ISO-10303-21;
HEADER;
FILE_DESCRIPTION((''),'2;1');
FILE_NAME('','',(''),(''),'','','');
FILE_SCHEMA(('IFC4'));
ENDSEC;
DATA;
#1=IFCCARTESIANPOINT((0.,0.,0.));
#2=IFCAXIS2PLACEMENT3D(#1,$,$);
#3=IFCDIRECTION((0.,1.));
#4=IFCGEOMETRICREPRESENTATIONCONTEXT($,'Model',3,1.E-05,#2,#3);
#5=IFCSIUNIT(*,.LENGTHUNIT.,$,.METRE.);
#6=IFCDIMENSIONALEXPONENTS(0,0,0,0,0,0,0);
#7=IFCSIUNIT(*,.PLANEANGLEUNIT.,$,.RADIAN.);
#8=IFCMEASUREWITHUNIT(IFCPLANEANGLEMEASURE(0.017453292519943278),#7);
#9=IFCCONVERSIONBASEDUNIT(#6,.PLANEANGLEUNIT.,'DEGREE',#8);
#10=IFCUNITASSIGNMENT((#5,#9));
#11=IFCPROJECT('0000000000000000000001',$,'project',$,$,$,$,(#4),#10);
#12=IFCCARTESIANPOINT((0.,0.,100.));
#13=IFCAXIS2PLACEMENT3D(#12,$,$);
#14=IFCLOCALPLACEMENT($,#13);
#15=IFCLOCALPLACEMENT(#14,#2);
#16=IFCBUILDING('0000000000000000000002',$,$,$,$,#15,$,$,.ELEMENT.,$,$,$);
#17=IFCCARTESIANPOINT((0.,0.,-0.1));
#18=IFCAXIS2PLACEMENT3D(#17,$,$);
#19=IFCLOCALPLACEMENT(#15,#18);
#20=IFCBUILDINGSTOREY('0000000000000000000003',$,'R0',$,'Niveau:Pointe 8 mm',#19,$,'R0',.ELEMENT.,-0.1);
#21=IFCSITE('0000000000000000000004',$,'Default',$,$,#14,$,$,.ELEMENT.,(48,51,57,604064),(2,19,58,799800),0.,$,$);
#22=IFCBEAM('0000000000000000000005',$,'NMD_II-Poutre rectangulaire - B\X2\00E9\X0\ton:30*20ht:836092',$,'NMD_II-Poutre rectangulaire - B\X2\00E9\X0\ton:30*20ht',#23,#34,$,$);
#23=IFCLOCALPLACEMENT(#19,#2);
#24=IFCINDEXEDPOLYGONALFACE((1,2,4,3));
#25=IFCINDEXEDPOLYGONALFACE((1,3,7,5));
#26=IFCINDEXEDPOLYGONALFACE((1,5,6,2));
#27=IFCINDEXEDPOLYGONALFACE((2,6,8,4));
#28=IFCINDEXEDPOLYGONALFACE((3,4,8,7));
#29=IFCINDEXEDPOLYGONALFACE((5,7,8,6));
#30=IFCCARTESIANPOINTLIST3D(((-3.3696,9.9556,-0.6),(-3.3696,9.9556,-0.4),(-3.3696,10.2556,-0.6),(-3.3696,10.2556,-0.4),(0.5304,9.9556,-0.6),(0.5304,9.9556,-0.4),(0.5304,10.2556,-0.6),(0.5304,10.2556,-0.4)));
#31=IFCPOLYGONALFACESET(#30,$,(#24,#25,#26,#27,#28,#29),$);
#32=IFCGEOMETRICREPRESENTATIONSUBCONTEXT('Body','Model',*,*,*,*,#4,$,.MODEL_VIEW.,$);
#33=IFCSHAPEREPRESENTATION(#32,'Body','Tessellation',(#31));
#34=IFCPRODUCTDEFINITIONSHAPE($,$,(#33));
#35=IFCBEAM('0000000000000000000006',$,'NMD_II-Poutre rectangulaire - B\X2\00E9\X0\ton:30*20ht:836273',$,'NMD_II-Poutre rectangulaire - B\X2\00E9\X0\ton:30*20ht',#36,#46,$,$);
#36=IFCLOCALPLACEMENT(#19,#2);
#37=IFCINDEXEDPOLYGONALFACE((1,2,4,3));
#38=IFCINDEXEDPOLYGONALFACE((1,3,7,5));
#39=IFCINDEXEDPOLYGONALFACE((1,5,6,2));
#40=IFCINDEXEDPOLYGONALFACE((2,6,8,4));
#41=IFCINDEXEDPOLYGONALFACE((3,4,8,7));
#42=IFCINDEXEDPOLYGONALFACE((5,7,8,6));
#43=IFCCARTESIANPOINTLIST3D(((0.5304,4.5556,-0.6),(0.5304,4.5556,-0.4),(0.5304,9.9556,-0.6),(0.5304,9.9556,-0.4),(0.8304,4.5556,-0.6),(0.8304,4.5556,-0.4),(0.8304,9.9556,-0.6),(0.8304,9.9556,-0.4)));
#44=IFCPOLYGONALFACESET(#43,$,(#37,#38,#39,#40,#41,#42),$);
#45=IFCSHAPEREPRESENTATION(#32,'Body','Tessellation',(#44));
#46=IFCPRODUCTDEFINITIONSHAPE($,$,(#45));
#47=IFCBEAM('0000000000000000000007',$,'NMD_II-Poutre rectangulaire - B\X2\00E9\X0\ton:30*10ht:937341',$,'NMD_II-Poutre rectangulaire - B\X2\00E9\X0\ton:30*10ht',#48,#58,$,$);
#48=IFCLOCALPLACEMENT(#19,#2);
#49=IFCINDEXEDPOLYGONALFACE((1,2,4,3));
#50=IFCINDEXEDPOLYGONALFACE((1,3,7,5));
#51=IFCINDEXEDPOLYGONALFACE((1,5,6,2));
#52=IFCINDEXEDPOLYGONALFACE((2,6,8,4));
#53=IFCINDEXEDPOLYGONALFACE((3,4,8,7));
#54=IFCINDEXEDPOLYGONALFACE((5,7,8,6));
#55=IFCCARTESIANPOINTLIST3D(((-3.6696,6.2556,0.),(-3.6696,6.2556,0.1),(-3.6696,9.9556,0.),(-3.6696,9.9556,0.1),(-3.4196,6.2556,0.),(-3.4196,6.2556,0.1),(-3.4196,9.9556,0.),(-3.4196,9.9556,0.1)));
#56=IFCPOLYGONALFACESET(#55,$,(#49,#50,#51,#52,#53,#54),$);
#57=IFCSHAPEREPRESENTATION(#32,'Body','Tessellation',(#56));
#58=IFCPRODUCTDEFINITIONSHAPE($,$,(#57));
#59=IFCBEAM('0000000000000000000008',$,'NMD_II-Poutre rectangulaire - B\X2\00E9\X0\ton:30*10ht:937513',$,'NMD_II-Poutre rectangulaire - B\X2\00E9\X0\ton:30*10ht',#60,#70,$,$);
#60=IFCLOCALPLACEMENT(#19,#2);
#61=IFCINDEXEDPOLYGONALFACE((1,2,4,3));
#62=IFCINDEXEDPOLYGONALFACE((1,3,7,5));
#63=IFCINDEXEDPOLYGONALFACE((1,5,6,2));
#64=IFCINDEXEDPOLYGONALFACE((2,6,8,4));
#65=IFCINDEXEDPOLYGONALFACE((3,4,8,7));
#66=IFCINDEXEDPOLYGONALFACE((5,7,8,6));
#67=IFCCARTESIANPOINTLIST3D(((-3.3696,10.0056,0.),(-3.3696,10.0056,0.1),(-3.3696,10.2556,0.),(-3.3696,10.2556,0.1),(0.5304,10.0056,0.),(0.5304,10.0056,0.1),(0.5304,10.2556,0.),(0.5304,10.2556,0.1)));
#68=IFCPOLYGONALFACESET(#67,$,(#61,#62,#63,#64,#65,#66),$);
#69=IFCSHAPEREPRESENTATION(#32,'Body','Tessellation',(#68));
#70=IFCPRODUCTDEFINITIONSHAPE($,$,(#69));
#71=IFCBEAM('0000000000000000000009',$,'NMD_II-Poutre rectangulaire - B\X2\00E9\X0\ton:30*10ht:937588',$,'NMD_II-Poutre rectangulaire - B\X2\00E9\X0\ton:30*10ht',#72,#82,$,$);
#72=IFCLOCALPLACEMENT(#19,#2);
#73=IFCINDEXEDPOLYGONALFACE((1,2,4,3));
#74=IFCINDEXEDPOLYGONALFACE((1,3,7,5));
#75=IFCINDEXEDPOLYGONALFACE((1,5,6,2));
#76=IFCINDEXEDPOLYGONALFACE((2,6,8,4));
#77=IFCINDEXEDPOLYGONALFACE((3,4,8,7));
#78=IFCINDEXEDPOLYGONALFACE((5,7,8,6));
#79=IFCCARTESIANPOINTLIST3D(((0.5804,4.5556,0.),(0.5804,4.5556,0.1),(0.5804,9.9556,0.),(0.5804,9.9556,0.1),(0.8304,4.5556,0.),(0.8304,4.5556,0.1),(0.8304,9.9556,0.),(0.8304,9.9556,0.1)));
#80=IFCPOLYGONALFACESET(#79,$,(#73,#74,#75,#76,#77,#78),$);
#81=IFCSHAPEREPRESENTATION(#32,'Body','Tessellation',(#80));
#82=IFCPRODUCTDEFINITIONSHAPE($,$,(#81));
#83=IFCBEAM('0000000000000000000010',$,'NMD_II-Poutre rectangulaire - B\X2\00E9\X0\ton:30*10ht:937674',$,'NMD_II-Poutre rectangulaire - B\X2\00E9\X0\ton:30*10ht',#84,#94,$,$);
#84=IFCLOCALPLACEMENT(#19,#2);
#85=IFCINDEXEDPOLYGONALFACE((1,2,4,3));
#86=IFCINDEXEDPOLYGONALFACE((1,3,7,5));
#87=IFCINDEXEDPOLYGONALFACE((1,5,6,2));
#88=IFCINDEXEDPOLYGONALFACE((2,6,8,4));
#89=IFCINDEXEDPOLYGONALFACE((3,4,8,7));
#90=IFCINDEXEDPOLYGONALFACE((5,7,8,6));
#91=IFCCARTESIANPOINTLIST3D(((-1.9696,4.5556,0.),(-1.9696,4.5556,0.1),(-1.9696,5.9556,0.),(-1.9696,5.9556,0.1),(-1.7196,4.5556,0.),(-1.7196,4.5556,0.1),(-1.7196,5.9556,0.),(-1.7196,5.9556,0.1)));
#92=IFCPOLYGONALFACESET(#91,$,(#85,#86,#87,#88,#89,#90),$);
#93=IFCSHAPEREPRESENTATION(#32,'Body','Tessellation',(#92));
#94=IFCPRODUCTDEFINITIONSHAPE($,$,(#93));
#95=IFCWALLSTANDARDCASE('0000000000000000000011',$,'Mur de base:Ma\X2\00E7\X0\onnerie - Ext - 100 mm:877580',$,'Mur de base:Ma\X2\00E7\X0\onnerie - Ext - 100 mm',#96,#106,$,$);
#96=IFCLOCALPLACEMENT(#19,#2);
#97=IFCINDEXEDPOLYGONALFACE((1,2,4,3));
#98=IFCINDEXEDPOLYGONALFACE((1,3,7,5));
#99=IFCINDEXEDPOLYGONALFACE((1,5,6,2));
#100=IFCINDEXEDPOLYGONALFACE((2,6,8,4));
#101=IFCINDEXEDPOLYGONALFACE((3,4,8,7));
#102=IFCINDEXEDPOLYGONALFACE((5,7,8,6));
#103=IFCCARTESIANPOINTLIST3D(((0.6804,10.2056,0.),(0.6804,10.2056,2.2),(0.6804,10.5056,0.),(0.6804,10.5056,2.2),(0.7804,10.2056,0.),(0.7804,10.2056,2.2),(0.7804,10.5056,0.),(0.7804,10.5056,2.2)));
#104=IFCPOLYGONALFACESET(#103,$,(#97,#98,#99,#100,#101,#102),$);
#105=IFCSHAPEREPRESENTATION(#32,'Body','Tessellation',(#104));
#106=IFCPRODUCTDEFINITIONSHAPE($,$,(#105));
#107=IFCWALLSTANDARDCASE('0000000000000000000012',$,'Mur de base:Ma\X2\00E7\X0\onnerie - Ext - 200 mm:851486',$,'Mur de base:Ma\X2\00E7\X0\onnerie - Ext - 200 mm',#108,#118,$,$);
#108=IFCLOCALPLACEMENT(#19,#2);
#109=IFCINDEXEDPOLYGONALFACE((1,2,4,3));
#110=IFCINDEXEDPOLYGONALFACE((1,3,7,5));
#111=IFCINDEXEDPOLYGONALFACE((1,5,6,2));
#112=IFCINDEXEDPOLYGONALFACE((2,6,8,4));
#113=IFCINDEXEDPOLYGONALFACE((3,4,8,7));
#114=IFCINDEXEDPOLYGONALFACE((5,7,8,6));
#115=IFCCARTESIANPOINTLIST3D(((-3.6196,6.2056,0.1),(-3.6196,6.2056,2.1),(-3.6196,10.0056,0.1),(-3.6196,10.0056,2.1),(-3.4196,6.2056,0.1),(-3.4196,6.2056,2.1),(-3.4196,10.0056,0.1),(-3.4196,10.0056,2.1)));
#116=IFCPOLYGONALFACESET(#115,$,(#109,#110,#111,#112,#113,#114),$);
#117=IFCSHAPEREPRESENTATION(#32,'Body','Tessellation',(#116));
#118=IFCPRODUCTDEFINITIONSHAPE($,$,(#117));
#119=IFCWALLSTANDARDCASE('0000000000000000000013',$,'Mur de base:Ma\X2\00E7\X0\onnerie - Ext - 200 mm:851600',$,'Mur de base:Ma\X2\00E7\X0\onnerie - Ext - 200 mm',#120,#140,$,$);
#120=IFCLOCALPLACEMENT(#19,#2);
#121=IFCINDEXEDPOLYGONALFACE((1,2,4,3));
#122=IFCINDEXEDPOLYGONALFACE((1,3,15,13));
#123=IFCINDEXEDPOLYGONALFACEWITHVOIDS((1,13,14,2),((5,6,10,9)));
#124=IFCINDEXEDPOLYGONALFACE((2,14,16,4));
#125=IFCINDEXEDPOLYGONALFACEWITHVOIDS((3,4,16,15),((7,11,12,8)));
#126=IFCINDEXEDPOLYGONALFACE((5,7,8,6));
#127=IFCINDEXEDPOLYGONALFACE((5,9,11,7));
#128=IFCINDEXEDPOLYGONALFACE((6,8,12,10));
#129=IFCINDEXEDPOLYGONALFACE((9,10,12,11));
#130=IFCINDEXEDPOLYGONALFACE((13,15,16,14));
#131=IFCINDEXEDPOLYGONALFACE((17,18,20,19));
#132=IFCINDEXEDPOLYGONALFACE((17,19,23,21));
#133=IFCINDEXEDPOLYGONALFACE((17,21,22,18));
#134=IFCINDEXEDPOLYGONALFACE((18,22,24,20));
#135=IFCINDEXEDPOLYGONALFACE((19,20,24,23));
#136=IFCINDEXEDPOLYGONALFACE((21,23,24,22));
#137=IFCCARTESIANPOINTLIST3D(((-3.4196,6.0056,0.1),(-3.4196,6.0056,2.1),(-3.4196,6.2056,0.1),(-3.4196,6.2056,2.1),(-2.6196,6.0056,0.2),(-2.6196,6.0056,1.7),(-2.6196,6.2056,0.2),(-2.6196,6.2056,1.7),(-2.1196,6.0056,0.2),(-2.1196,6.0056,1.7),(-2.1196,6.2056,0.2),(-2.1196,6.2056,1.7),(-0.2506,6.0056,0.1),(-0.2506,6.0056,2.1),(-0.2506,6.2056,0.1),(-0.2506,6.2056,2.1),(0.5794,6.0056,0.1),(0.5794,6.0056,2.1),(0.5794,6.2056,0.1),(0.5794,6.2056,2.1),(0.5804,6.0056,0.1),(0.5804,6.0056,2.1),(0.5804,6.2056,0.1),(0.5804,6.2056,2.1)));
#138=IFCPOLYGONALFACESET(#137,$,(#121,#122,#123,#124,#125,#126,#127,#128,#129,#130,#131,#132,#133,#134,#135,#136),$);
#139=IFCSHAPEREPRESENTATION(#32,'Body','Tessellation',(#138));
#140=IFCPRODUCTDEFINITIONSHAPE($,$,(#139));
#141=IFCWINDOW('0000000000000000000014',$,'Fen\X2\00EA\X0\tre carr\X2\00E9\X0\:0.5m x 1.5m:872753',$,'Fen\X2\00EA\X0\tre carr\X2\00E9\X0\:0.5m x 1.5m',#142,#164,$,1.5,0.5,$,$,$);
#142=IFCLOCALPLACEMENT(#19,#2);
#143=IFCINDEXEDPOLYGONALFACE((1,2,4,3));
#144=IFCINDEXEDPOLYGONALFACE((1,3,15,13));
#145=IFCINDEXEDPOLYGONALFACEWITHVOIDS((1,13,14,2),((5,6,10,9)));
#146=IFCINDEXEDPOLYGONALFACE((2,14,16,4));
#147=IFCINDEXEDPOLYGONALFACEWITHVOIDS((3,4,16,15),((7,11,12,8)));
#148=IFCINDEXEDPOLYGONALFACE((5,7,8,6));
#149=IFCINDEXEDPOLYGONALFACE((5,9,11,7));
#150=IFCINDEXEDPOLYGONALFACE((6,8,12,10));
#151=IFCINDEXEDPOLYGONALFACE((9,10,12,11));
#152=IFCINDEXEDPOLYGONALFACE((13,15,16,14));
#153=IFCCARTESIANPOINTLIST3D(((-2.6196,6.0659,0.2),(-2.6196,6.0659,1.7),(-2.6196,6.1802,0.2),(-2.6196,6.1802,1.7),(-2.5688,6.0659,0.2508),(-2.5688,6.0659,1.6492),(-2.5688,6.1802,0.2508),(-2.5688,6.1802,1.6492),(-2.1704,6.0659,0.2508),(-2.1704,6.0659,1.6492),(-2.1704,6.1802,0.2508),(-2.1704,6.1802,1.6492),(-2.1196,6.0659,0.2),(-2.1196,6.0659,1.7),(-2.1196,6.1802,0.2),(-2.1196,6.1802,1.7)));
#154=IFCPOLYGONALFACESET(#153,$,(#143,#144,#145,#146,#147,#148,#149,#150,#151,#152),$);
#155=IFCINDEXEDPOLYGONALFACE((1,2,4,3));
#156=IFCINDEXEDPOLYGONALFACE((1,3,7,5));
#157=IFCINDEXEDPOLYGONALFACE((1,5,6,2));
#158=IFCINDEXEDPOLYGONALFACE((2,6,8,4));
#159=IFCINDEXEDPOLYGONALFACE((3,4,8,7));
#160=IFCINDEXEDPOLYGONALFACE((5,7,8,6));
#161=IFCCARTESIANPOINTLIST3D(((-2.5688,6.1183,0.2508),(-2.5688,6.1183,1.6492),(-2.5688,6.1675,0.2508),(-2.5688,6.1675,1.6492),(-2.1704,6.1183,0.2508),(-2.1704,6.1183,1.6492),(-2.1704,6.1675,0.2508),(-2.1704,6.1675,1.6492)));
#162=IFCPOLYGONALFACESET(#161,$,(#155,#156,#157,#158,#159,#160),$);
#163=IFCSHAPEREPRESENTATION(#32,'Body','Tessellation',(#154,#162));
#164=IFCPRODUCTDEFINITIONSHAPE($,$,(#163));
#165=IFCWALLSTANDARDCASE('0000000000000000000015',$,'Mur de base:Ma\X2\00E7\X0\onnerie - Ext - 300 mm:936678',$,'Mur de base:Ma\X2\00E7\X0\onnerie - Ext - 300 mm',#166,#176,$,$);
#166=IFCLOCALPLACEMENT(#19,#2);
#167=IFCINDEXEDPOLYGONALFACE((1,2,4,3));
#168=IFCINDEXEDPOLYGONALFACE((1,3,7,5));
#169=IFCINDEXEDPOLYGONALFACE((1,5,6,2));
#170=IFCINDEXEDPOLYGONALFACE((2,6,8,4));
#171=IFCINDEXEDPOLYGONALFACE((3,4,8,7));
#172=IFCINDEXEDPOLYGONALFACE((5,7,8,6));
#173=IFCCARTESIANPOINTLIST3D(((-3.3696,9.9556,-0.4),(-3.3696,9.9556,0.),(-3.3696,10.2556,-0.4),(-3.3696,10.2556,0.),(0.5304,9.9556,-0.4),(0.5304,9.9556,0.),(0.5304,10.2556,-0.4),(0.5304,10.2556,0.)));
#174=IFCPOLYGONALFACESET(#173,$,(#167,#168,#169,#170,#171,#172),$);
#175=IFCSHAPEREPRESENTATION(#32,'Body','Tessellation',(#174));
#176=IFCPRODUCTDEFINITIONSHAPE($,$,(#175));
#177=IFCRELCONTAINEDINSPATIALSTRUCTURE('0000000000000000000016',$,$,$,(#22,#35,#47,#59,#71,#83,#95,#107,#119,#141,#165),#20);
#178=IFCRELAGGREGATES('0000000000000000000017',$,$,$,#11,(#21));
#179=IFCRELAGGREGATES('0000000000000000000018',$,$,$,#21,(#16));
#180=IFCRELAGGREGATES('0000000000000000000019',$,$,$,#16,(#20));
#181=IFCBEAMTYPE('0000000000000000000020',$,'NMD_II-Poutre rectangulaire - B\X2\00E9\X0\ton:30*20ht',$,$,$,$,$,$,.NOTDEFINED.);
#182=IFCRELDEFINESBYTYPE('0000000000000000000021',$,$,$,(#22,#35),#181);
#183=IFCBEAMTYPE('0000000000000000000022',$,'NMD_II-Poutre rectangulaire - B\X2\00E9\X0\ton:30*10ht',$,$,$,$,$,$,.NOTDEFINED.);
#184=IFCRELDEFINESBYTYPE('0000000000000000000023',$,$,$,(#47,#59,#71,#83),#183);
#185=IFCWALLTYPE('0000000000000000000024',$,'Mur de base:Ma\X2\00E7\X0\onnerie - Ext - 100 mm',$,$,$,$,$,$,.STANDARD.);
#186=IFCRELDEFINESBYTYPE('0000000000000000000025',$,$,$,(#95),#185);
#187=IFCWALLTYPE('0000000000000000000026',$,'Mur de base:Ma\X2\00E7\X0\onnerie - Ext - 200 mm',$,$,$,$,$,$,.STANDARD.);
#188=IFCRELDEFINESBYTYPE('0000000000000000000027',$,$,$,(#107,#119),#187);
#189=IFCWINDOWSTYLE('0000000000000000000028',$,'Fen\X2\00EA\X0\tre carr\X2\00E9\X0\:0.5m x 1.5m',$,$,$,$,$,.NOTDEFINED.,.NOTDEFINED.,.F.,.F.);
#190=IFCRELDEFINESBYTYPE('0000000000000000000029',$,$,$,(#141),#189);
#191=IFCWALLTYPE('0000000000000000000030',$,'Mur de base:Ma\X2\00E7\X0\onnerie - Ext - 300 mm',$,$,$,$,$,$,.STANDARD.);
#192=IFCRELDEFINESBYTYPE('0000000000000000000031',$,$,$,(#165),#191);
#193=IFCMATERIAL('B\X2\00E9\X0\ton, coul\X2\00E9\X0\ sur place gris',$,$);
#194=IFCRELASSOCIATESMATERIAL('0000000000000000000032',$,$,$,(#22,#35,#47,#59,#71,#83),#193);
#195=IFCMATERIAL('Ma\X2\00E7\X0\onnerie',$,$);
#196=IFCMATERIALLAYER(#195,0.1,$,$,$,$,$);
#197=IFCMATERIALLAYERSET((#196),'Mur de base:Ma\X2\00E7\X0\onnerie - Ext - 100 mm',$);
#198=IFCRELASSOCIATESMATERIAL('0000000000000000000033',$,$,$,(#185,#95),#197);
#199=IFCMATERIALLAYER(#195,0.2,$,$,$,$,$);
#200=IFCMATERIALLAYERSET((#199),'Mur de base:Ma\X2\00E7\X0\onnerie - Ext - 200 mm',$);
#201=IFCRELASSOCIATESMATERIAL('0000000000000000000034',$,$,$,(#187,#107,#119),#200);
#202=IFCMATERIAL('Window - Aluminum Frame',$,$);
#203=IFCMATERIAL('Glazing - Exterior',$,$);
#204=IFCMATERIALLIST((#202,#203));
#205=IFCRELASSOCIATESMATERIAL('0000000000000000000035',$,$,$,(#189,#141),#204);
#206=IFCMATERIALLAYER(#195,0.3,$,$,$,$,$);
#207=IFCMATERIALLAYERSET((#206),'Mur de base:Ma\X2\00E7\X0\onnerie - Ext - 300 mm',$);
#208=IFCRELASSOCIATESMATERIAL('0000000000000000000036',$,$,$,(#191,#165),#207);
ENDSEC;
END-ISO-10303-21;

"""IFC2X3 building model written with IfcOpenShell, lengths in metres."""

from ifc_helpers import new_model, entity, si_unit, converted_unit, direction, frame, frame_2d, origin, place, context, subcontext, project, spatial, polyline, rectangle, outline, extrude, clip, bounded_halfspace, source, transform, mapped, material, material_list, layer, layer_set, layer_usage, type_object, type_shapes, element, fill, save


model = new_model("IFC2X3")

# Units and contexts
model_context = context("Model", 3, precision=1e-05, world=origin(), true_north=direction((0.0, 1.0)))
body_context = subcontext(model_context, "Body", "Model", "MODEL_VIEW")
ifc_project = project(units=[si_unit("LENGTHUNIT", "METRE"), converted_unit("PLANEANGLEUNIT", "DEGREE", entity("IfcPlaneAngleMeasure", 0.017453292519943278), si_unit("PLANEANGLEUNIT", "RADIAN"), dimensions=[0, 0, 0, 0, 0, 0, 0])], contexts=[model_context])

# Site, building, storey
site_placement = place(None, frame((0.0, 0.0, 100.0)))
site = spatial("IfcSite", under=ifc_project, at=site_placement, Name="Default", CompositionType="ELEMENT", RefLatitude=(48, 51, 57, 604064), RefLongitude=(2, 19, 58, 799800), RefElevation=0.0)
building_placement = place(site_placement, origin())
building = spatial("IfcBuilding", under=site, at=building_placement, CompositionType="ELEMENT")
storey_placement = place(building_placement, frame((0.0, 0.0, -0.1)))
storey = spatial("IfcBuildingStorey", under=building, at=storey_placement, Name="R0", ObjectType="Niveau:Pointe 8 mm", LongName="R0", CompositionType="ELEMENT", Elevation=-0.1)

# Beams
ifc_material_1 = material(Name="Béton, coulé sur place gris")
beam_type_1 = type_object("IfcBeamType", Name="NMD_II-Poutre rectangulaire - Béton:30*20ht", PredefinedType="NOTDEFINED")
beam_1_placement = place(storey_placement, frame((-3.3696, 10.1056, -0.4)))
element("IfcBeam", 1, at=beam_1_placement, inside=storey, type_object=beam_type_1, material=ifc_material_1, Name="NMD_II-Poutre rectangulaire - Béton:30*20ht:836092", ObjectType="NMD_II-Poutre rectangulaire - Béton:30*20ht", context=body_context, shape_type="SweptSolid", body=[
    extrude(rectangle(XDim=0.2, YDim=0.3, at=frame_2d((0.0, 0.0), x_axis=(1.0, 0.0))), frame((0.0, 0.0, -0.1), z_axis=(1.0, 0.0, 0.0), x_axis=(0.0, 0.0, -1.0)), (0.0, 0.0, 1.0), 3.9),
])
beam_2_placement = place(storey_placement, frame((0.6804, 4.5556, -0.4), z_axis=(0.0, 0.0, 1.0), x_axis=(0.0, 1.0, 0.0)))
element("IfcBeam", 2, at=beam_2_placement, inside=storey, type_object=beam_type_1, material=ifc_material_1, Name="NMD_II-Poutre rectangulaire - Béton:30*20ht:836273", ObjectType="NMD_II-Poutre rectangulaire - Béton:30*20ht", context=body_context, shape_type="SweptSolid", body=[
    extrude(rectangle(XDim=0.2, YDim=0.3, at=frame_2d((0.0, 0.0), x_axis=(1.0, 0.0))), frame((0.0, 0.0, -0.1), z_axis=(1.0, 0.0, 0.0), x_axis=(0.0, 0.0, -1.0)), (0.0, 0.0, 1.0), 5.4),
])
beam_type_2 = type_object("IfcBeamType", Name="NMD_II-Poutre rectangulaire - Béton:30*10ht", PredefinedType="NOTDEFINED")
beam_3_placement = place(storey_placement, frame((-3.5196, 9.9556, 0.1), z_axis=(0.0, 0.0, 1.0), x_axis=(0.0, -1.0, 0.0)))
element("IfcBeam", 3, at=beam_3_placement, inside=storey, type_object=beam_type_2, material=ifc_material_1, Name="NMD_II-Poutre rectangulaire - Béton:30*10ht:937341", ObjectType="NMD_II-Poutre rectangulaire - Béton:30*10ht", context=body_context, shape_type="SweptSolid", body=[
    extrude(rectangle(XDim=0.1, YDim=0.25, at=frame_2d((0.0, 0.0), x_axis=(1.0, 0.0))), frame((0.0, -0.025, -0.05), z_axis=(1.0, 0.0, 0.0), x_axis=(0.0, 0.0, -1.0)), (0.0, 0.0, 1.0), 3.7),
])
beam_4_placement = place(storey_placement, frame((-3.3696, 10.1056, 0.1)))
element("IfcBeam", 4, at=beam_4_placement, inside=storey, type_object=beam_type_2, material=ifc_material_1, Name="NMD_II-Poutre rectangulaire - Béton:30*10ht:937513", ObjectType="NMD_II-Poutre rectangulaire - Béton:30*10ht", context=body_context, shape_type="SweptSolid", body=[
    extrude(rectangle(XDim=0.1, YDim=0.25, at=frame_2d((0.0, 0.0), x_axis=(1.0, 0.0))), frame((0.0, 0.025, -0.05), z_axis=(1.0, 0.0, 0.0), x_axis=(0.0, 0.0, -1.0)), (0.0, 0.0, 1.0), 3.9),
])
beam_5_placement = place(storey_placement, frame((0.6804, 4.5556, 0.1), z_axis=(0.0, 0.0, 1.0), x_axis=(0.0, 1.0, 0.0)))
element("IfcBeam", 5, at=beam_5_placement, inside=storey, type_object=beam_type_2, material=ifc_material_1, Name="NMD_II-Poutre rectangulaire - Béton:30*10ht:937588", ObjectType="NMD_II-Poutre rectangulaire - Béton:30*10ht", context=body_context, shape_type="SweptSolid", body=[
    extrude(rectangle(XDim=0.1, YDim=0.25, at=frame_2d((0.0, 0.0), x_axis=(1.0, 0.0))), frame((0.0, -0.025, -0.05), z_axis=(1.0, 0.0, 0.0), x_axis=(0.0, 0.0, -1.0)), (0.0, 0.0, 1.0), 5.4),
])
beam_6_placement = place(storey_placement, frame((-1.8196, 5.9556, 0.1), z_axis=(0.0, 0.0, 1.0), x_axis=(0.0, -1.0, 0.0)))
element("IfcBeam", 6, at=beam_6_placement, inside=storey, type_object=beam_type_2, material=ifc_material_1, Name="NMD_II-Poutre rectangulaire - Béton:30*10ht:937674", ObjectType="NMD_II-Poutre rectangulaire - Béton:30*10ht", context=body_context, shape_type="SweptSolid", body=[
    extrude(rectangle(XDim=0.1, YDim=0.25, at=frame_2d((0.0, 0.0), x_axis=(1.0, 0.0))), frame((0.0, -0.025, -0.05), z_axis=(1.0, 0.0, 0.0), x_axis=(0.0, 0.0, -1.0)), (0.0, 0.0, 1.0), 1.4),
])

# Walls
ifc_material_2 = material(Name="Maçonnerie")
ifc_layer_1 = layer(ifc_material_2, 0.1)
ifc_layer_set_1 = layer_set([ifc_layer_1], Name="Mur de base:Maçonnerie - Ext - 100 mm")
ifc_layer_usage_1 = layer_usage(ifc_layer_set_1, "AXIS2", "NEGATIVE", 0.05)
wall_type_1 = type_object("IfcWallType", Name="Mur de base:Maçonnerie - Ext - 100 mm", PredefinedType="STANDARD", material=ifc_layer_set_1)
wall_1_placement = place(storey_placement, frame((0.7304, 10.2056, 0.0), z_axis=(0.0, 0.0, 1.0), x_axis=(0.0, 1.0, 0.0)))
element("IfcWallStandardCase", 7, at=wall_1_placement, inside=storey, type_object=wall_type_1, material=ifc_layer_usage_1, Name="Mur de base:Maçonnerie - Ext - 100 mm:877580", ObjectType="Mur de base:Maçonnerie - Ext - 100 mm", context=body_context, shape_type="SweptSolid", body=[
    extrude(rectangle(XDim=0.3, YDim=0.1, at=frame_2d((0.15, 0.0), x_axis=(-1.0, 0.0))), origin(), (0.0, 0.0, 1.0), 2.2),
])
ifc_layer_2 = layer(ifc_material_2, 0.2)
ifc_layer_set_2 = layer_set([ifc_layer_2], Name="Mur de base:Maçonnerie - Ext - 200 mm")
ifc_layer_usage_2 = layer_usage(ifc_layer_set_2, "AXIS2", "NEGATIVE", 0.1)
wall_type_2 = type_object("IfcWallType", Name="Mur de base:Maçonnerie - Ext - 200 mm", PredefinedType="STANDARD", material=ifc_layer_set_2)
wall_2_placement = place(storey_placement, frame((-3.5196, 10.0056, 0.1), z_axis=(0.0, 0.0, 1.0), x_axis=(0.0, -1.0, 0.0)))
element("IfcWallStandardCase", 8, at=wall_2_placement, inside=storey, type_object=wall_type_2, material=ifc_layer_usage_2, Name="Mur de base:Maçonnerie - Ext - 200 mm:851486", ObjectType="Mur de base:Maçonnerie - Ext - 200 mm", context=body_context, shape_type="Clipping", body=[
    clip(extrude(rectangle(XDim=3.8, YDim=0.2, at=frame_2d((1.9, 0.0), x_axis=(-1.0, 0.0))), origin(), (0.0, 0.0, 1.0), 2.0), bounded_halfspace(frame((3.8, -0.1, 2.0), z_axis=(-1.0, 0.0, 0.0), x_axis=(0.0, 0.0, -1.0)), True, frame((3.8, -0.1, 2.0), z_axis=(-1.0, 0.0, 0.0), x_axis=(0.0, 0.0, -1.0)), polyline([(0.0, 0.0), (0.0, -0.2), (2.0, -0.2), (2.0, 0.0), (0.0, 0.0)]))),
])

# Wall, openings, window
ifc_layer_usage_3 = layer_usage(ifc_layer_set_2, "AXIS2", "NEGATIVE", 0.1)
wall_3_placement = place(storey_placement, frame((-3.4196, 6.1056, 0.1)))
wall_3 = element("IfcWallStandardCase", 9, at=wall_3_placement, inside=storey, type_object=wall_type_2, material=ifc_layer_usage_3, Name="Mur de base:Maçonnerie - Ext - 200 mm:851600", ObjectType="Mur de base:Maçonnerie - Ext - 200 mm", context=body_context, shape_type="SweptSolid", body=[
    extrude(rectangle(XDim=4.0, YDim=0.2, at=frame_2d((2.0, 0.0), x_axis=(-1.0, 0.0))), origin(), (0.0, 0.0, 1.0), 2.0),
])
opening_1_placement = place(wall_3_placement, frame((3.999, 0.1, 0.0)))
element("IfcOpeningElement", 10, at=opening_1_placement, cuts=wall_3, ObjectType="Opening", context=body_context, shape_type="SweptSolid", body=[
    extrude(rectangle(XDim=2.0, YDim=0.83, at=frame_2d((1.0, 0.415), x_axis=(1.0, 0.0))), frame((0.0, 0.0, 0.0), z_axis=(0.0, -1.0, 0.0), x_axis=(0.0, 0.0, 1.0)), (0.0, 0.0, 1.0), 0.2),
])
opening_2_placement = place(wall_3_placement, frame((0.8, -0.1, 0.1)))
opening_2 = element("IfcOpeningElement", 11, at=opening_2_placement, cuts=wall_3, ObjectType="Opening", context=body_context, shape_type="SweptSolid", body=[
    extrude(rectangle(XDim=1.5, YDim=0.5, at=frame_2d((0.75, 0.25), x_axis=(-1.0, 0.0))), frame((0.0, 0.0, 0.0), z_axis=(0.0, 1.0, 0.0), x_axis=(0.0, 0.0, 1.0)), (0.0, 0.0, 1.0), 0.2),
])
ifc_material_3 = material(Name="Window - Aluminum Frame")
ifc_material_4 = material(Name="Glazing - Exterior")
ifc_material_list_1 = material_list([ifc_material_3, ifc_material_4])
window_style = type_object("IfcWindowStyle", Name="Fenêtre carré:0.5m x 1.5m", ConstructionType="NOTDEFINED", OperationType="NOTDEFINED", ParameterTakesPrecedence=False, Sizeable=False, material=ifc_material_list_1)
shared_shape_1 = source(origin(), body_context, "Body", "SweptSolid", [
    extrude(outline(polyline([(-0.25, -0.75), (0.25, -0.75), (0.25, 0.75), (-0.25, 0.75), (-0.25, -0.75)]), holes=[polyline([(-0.1992, -0.6992), (-0.1992, 0.6992), (0.1992, 0.6992), (0.1992, -0.6992), (-0.1992, -0.6992)])]), frame((0.25, 0.0603, 0.75), z_axis=(0.0, 1.0, 0.0), x_axis=(1.0, 0.0, 0.0)), (0.0, 0.0, 1.0), 0.1143),
    extrude(rectangle(XDim=0.0492, YDim=0.3984, at=frame_2d((0.0, 0.0), x_axis=(1.0, 0.0))), frame((0.25, 0.1373, 0.0508), z_axis=(0.0, 0.0, 1.0), x_axis=(0.0, -1.0, 0.0)), (0.0, 0.0, 1.0), 1.3984),
])
type_shapes(window_style, [shared_shape_1])
window_placement = place(opening_2_placement, origin())
window = element("IfcWindow", 12, at=window_placement, inside=storey, type_object=window_style, material=ifc_material_list_1, Name="Fenêtre carré:0.5m x 1.5m:872753", ObjectType="Fenêtre carré:0.5m x 1.5m", OverallHeight=1.5, OverallWidth=0.5, context=body_context, shape_type="MappedRepresentation", body=[
    mapped(shared_shape_1, transform((0.0, 0.0, 0.0), scale=1.0)),
])
fill(opening_2, window)

# Wall
ifc_layer_3 = layer(ifc_material_2, 0.3)
ifc_layer_set_3 = layer_set([ifc_layer_3], Name="Mur de base:Maçonnerie - Ext - 300 mm")
ifc_layer_usage_4 = layer_usage(ifc_layer_set_3, "AXIS2", "NEGATIVE", 0.15)
wall_type_3 = type_object("IfcWallType", Name="Mur de base:Maçonnerie - Ext - 300 mm", PredefinedType="STANDARD", material=ifc_layer_set_3)
wall_4_placement = place(storey_placement, frame((-3.3696, 10.1056, -0.4)))
element("IfcWallStandardCase", 13, at=wall_4_placement, inside=storey, type_object=wall_type_3, material=ifc_layer_usage_4, Name="Mur de base:Maçonnerie - Ext - 300 mm:936678", ObjectType="Mur de base:Maçonnerie - Ext - 300 mm", context=body_context, shape_type="SweptSolid", body=[
    extrude(rectangle(XDim=3.9, YDim=0.3, at=frame_2d((1.95, 0.0), x_axis=(-1.0, 0.0))), origin(), (0.0, 0.0, 1.0), 0.4),
])

save(model, "model.ifc")
